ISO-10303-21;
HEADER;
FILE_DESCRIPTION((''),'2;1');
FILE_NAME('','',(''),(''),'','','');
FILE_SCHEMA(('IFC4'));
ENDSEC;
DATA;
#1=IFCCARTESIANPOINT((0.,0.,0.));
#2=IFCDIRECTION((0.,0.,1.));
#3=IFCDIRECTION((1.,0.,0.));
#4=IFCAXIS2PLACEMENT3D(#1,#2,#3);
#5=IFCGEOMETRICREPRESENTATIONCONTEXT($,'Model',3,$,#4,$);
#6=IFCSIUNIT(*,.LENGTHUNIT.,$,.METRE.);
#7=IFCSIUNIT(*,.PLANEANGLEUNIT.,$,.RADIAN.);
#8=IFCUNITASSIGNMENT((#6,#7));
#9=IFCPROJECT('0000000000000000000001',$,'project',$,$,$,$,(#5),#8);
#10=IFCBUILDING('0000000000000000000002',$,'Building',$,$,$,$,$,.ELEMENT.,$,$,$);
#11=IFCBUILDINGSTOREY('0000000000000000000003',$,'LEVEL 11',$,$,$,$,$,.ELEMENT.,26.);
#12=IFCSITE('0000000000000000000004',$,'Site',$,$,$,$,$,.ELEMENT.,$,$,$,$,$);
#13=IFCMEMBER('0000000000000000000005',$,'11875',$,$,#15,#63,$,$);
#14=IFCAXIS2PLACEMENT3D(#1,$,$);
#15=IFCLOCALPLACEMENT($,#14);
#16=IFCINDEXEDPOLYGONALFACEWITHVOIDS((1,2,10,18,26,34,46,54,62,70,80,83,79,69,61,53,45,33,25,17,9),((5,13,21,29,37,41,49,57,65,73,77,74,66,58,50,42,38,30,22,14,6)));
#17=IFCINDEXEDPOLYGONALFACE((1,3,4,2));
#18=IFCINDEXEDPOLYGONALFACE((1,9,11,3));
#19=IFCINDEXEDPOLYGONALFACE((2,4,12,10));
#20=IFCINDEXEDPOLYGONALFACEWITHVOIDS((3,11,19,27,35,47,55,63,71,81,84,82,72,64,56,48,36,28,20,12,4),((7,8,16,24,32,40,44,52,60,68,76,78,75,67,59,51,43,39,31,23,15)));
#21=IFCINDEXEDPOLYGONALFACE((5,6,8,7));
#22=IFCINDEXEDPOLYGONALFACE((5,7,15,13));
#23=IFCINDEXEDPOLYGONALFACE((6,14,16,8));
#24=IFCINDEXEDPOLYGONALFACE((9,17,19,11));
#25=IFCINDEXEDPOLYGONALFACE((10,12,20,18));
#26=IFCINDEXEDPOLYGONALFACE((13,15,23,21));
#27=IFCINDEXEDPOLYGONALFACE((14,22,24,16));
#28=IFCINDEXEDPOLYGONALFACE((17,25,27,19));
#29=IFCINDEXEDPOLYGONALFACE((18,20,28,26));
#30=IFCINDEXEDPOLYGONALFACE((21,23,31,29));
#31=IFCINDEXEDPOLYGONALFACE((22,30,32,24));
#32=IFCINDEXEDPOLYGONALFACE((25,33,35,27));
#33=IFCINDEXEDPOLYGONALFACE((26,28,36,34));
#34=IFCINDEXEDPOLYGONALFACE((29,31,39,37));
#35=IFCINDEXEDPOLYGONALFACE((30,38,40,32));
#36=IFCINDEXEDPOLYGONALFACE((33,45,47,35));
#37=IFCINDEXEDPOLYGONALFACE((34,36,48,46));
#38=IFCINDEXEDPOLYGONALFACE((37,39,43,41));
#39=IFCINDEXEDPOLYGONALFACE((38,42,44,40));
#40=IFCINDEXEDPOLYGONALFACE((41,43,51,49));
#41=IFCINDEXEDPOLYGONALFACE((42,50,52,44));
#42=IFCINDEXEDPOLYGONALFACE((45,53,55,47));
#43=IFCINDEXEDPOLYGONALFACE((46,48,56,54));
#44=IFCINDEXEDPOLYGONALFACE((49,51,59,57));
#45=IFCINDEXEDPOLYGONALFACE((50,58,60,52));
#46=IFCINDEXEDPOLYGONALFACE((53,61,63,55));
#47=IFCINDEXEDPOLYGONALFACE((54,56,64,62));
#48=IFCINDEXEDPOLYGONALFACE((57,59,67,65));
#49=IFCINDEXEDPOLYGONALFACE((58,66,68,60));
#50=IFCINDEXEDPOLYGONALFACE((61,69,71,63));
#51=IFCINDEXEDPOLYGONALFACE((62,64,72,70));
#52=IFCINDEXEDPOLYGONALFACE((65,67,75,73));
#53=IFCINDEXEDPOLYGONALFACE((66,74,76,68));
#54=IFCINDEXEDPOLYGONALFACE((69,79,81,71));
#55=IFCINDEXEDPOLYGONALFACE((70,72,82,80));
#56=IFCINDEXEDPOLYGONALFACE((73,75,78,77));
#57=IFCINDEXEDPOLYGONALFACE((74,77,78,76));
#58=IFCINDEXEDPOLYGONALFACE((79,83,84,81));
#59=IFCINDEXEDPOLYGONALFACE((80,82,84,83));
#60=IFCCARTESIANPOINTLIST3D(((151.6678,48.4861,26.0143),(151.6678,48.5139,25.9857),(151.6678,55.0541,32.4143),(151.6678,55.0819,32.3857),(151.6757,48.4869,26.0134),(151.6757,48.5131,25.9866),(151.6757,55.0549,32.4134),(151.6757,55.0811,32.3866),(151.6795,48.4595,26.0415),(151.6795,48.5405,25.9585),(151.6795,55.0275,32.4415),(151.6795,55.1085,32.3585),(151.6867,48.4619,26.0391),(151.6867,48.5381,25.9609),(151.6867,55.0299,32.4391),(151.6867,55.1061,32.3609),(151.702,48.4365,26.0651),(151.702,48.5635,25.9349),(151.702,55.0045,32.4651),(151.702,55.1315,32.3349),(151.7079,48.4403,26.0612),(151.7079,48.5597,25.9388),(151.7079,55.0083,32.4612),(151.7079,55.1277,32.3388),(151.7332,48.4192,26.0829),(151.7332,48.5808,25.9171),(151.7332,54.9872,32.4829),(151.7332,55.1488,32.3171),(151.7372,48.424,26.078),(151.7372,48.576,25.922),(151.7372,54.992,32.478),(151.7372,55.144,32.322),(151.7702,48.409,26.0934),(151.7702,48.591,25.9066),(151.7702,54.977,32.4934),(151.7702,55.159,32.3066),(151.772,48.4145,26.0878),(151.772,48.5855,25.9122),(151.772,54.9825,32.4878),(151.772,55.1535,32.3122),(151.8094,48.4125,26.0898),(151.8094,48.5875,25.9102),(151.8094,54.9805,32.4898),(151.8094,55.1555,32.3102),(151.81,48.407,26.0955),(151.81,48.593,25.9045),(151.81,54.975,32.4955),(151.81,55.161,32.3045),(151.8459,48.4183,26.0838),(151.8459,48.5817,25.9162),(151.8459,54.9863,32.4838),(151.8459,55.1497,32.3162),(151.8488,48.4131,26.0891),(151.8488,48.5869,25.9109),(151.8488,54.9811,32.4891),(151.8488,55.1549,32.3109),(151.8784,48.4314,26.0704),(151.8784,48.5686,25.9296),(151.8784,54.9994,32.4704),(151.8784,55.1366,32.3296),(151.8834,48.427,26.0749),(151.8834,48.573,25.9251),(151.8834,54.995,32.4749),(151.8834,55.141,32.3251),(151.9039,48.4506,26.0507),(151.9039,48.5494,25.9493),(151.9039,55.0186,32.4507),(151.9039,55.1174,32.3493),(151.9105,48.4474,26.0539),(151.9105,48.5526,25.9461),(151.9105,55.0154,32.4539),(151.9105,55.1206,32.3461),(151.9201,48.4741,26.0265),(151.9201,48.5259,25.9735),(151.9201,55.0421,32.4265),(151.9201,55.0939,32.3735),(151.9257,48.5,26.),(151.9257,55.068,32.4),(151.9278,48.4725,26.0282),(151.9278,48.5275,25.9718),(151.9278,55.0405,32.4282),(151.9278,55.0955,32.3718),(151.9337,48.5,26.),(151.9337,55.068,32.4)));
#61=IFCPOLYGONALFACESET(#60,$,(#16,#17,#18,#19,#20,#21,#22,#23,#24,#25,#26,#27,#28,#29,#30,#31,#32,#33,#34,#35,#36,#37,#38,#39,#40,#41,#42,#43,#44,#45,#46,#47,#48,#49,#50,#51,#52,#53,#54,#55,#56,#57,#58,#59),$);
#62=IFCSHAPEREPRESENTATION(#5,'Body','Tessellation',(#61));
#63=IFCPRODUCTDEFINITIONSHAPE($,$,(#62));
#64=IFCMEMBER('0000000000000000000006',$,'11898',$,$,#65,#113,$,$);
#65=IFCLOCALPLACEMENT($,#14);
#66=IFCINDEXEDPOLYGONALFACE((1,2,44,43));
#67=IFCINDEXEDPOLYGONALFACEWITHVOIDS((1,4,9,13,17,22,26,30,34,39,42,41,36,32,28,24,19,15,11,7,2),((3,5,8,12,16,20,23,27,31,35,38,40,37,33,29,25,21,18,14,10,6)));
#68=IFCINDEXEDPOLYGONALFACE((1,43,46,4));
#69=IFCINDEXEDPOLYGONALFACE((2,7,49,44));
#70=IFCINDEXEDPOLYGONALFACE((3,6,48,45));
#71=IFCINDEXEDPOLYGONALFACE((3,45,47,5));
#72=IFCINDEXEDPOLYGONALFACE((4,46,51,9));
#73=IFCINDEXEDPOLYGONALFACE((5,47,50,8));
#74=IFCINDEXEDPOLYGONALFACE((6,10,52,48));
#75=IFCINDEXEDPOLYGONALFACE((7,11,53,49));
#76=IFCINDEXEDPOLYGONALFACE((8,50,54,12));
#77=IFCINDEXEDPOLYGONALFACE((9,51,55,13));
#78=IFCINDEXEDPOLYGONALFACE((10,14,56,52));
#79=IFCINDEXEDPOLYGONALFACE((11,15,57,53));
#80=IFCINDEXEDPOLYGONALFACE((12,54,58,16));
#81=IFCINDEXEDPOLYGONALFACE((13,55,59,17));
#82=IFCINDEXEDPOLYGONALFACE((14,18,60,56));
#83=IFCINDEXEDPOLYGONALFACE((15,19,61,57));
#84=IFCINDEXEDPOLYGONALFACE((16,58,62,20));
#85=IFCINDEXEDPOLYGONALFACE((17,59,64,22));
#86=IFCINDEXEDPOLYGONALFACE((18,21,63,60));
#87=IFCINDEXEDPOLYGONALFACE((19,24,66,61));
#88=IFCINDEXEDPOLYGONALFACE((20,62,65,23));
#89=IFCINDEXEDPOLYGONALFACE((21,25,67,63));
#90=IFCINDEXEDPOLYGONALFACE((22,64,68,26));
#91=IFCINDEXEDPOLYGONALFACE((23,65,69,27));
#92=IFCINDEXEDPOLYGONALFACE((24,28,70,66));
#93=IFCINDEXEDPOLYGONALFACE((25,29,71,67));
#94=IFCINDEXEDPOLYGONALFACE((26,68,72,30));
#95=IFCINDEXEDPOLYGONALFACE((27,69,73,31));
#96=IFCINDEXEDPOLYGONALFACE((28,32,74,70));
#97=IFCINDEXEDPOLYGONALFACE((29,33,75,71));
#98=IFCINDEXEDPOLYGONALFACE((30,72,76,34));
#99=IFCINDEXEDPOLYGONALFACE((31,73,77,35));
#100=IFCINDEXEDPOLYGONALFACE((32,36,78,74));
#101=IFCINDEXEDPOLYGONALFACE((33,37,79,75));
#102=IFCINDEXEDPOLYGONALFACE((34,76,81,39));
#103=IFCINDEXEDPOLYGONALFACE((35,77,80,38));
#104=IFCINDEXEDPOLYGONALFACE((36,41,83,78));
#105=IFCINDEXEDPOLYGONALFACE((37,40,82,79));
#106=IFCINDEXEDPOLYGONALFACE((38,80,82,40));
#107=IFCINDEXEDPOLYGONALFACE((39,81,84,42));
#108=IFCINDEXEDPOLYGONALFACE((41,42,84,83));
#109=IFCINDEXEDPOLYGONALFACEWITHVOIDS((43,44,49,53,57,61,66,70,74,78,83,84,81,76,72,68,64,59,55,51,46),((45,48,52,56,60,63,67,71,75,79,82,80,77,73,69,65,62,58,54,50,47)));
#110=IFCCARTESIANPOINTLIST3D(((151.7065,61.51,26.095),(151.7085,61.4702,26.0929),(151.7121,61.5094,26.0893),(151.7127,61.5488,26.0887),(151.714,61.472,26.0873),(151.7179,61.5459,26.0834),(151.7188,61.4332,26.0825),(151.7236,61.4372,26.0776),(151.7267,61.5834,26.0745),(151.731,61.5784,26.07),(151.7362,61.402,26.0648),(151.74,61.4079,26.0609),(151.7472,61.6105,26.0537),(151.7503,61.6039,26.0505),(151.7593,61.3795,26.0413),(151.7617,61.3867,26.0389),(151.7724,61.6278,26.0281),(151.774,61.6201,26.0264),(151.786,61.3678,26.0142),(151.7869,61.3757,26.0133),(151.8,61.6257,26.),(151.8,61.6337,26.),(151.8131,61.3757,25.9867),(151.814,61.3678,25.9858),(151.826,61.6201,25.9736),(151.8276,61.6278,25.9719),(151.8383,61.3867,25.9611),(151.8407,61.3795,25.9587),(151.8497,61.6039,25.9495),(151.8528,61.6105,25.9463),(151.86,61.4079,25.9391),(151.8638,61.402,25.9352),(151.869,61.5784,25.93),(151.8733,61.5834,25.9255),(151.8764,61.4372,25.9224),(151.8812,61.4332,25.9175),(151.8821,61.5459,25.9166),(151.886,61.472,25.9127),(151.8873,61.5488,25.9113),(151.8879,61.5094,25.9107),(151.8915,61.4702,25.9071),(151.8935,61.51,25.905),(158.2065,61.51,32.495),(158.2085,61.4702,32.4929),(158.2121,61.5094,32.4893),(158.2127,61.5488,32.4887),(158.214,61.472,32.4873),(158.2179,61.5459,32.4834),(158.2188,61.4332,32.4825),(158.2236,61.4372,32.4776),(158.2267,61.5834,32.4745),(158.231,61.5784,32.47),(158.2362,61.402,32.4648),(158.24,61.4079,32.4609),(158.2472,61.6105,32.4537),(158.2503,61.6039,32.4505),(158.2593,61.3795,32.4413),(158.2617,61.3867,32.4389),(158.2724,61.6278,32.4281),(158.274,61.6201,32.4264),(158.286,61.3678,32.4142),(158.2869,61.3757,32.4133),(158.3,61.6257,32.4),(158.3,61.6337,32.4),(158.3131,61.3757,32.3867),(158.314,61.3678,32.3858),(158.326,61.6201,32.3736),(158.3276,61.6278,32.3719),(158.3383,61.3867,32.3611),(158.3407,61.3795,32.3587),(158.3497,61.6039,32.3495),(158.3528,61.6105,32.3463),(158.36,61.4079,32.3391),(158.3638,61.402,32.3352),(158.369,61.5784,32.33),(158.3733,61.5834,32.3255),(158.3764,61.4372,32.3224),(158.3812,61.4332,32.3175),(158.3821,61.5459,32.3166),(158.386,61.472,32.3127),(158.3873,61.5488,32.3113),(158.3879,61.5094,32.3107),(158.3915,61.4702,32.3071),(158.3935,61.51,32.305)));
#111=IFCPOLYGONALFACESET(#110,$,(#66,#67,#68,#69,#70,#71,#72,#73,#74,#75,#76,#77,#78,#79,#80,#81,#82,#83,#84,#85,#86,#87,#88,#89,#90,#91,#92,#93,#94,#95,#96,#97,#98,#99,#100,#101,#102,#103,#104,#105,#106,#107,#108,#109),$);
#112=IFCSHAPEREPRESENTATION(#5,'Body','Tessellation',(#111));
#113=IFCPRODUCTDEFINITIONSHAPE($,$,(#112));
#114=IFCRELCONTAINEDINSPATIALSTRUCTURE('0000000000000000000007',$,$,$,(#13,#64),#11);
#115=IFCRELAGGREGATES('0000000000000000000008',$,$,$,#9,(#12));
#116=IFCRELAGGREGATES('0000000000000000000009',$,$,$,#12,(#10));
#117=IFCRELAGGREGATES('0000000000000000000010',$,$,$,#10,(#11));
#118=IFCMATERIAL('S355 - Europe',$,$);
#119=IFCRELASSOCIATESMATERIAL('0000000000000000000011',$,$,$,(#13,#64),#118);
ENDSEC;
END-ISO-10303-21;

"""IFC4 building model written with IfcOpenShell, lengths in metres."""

from ifc_helpers import new_model, si_unit, frame, origin_with_axes, origin_2d_with_axis, place, context, project, spatial, hollow_circle, extrude, material, material_profile, profile_set, profile_usage, element, save


model = new_model("IFC4")

# Units and contexts
model_context = context("Model", 3, world=origin_with_axes())
ifc_project = project(units=[si_unit("LENGTHUNIT", "METRE"), si_unit("PLANEANGLEUNIT", "RADIAN")], contexts=[model_context])

# Site, building, storey
site = spatial("IfcSite", under=ifc_project, Name="Site", CompositionType="ELEMENT")
building = spatial("IfcBuilding", under=site, Name="Building", CompositionType="ELEMENT")
storey = spatial("IfcBuildingStorey", under=building, Name="LEVEL 11", CompositionType="ELEMENT", Elevation=26.0)

# Shared definitions
ifc_material = material(Name="S355 - Europe")

# Members
ifc_material_profile_1 = material_profile(ifc_material, hollow_circle(Radius=0.1337, WallThickness=0.008, at=origin_2d_with_axis()))
ifc_profile_set_1 = profile_set([ifc_material_profile_1])
ifc_profile_usage_1 = profile_usage(ifc_profile_set_1, cardinal=10)
member_1_placement = place(None, frame((151.8, 55.068, 32.4), z_axis=(0.0, -0.716207, -0.697888), x_axis=(1.0, 0.0, 0.0)))
element("IfcMember", 1, at=member_1_placement, inside=storey, material=ifc_profile_usage_1, Name="11875", context=model_context, shape_type="SweptSolid", body=[
    extrude(hollow_circle(Radius=0.1337, WallThickness=0.008, at=origin_2d_with_axis()), origin_with_axes(), (0.0, 0.0, 1.0), 9.1705),
])
ifc_material_profile_2 = material_profile(ifc_material, hollow_circle(Radius=0.1337, WallThickness=0.008, at=origin_2d_with_axis()))
ifc_profile_set_2 = profile_set([ifc_material_profile_2])
ifc_profile_usage_2 = profile_usage(ifc_profile_set_2, cardinal=10)
member_2_placement = place(None, frame((151.8, 61.5, 26.0), z_axis=(0.712567, 0.0, 0.701604), x_axis=(0.0, 1.0, 0.0)))
element("IfcMember", 2, at=member_2_placement, inside=storey, material=ifc_profile_usage_2, Name="11898", context=model_context, shape_type="SweptSolid", body=[
    extrude(hollow_circle(Radius=0.1337, WallThickness=0.008, at=origin_2d_with_axis()), origin_with_axes(), (0.0, 0.0, 1.0), 9.122),
])

save(model, "model.ifc")
